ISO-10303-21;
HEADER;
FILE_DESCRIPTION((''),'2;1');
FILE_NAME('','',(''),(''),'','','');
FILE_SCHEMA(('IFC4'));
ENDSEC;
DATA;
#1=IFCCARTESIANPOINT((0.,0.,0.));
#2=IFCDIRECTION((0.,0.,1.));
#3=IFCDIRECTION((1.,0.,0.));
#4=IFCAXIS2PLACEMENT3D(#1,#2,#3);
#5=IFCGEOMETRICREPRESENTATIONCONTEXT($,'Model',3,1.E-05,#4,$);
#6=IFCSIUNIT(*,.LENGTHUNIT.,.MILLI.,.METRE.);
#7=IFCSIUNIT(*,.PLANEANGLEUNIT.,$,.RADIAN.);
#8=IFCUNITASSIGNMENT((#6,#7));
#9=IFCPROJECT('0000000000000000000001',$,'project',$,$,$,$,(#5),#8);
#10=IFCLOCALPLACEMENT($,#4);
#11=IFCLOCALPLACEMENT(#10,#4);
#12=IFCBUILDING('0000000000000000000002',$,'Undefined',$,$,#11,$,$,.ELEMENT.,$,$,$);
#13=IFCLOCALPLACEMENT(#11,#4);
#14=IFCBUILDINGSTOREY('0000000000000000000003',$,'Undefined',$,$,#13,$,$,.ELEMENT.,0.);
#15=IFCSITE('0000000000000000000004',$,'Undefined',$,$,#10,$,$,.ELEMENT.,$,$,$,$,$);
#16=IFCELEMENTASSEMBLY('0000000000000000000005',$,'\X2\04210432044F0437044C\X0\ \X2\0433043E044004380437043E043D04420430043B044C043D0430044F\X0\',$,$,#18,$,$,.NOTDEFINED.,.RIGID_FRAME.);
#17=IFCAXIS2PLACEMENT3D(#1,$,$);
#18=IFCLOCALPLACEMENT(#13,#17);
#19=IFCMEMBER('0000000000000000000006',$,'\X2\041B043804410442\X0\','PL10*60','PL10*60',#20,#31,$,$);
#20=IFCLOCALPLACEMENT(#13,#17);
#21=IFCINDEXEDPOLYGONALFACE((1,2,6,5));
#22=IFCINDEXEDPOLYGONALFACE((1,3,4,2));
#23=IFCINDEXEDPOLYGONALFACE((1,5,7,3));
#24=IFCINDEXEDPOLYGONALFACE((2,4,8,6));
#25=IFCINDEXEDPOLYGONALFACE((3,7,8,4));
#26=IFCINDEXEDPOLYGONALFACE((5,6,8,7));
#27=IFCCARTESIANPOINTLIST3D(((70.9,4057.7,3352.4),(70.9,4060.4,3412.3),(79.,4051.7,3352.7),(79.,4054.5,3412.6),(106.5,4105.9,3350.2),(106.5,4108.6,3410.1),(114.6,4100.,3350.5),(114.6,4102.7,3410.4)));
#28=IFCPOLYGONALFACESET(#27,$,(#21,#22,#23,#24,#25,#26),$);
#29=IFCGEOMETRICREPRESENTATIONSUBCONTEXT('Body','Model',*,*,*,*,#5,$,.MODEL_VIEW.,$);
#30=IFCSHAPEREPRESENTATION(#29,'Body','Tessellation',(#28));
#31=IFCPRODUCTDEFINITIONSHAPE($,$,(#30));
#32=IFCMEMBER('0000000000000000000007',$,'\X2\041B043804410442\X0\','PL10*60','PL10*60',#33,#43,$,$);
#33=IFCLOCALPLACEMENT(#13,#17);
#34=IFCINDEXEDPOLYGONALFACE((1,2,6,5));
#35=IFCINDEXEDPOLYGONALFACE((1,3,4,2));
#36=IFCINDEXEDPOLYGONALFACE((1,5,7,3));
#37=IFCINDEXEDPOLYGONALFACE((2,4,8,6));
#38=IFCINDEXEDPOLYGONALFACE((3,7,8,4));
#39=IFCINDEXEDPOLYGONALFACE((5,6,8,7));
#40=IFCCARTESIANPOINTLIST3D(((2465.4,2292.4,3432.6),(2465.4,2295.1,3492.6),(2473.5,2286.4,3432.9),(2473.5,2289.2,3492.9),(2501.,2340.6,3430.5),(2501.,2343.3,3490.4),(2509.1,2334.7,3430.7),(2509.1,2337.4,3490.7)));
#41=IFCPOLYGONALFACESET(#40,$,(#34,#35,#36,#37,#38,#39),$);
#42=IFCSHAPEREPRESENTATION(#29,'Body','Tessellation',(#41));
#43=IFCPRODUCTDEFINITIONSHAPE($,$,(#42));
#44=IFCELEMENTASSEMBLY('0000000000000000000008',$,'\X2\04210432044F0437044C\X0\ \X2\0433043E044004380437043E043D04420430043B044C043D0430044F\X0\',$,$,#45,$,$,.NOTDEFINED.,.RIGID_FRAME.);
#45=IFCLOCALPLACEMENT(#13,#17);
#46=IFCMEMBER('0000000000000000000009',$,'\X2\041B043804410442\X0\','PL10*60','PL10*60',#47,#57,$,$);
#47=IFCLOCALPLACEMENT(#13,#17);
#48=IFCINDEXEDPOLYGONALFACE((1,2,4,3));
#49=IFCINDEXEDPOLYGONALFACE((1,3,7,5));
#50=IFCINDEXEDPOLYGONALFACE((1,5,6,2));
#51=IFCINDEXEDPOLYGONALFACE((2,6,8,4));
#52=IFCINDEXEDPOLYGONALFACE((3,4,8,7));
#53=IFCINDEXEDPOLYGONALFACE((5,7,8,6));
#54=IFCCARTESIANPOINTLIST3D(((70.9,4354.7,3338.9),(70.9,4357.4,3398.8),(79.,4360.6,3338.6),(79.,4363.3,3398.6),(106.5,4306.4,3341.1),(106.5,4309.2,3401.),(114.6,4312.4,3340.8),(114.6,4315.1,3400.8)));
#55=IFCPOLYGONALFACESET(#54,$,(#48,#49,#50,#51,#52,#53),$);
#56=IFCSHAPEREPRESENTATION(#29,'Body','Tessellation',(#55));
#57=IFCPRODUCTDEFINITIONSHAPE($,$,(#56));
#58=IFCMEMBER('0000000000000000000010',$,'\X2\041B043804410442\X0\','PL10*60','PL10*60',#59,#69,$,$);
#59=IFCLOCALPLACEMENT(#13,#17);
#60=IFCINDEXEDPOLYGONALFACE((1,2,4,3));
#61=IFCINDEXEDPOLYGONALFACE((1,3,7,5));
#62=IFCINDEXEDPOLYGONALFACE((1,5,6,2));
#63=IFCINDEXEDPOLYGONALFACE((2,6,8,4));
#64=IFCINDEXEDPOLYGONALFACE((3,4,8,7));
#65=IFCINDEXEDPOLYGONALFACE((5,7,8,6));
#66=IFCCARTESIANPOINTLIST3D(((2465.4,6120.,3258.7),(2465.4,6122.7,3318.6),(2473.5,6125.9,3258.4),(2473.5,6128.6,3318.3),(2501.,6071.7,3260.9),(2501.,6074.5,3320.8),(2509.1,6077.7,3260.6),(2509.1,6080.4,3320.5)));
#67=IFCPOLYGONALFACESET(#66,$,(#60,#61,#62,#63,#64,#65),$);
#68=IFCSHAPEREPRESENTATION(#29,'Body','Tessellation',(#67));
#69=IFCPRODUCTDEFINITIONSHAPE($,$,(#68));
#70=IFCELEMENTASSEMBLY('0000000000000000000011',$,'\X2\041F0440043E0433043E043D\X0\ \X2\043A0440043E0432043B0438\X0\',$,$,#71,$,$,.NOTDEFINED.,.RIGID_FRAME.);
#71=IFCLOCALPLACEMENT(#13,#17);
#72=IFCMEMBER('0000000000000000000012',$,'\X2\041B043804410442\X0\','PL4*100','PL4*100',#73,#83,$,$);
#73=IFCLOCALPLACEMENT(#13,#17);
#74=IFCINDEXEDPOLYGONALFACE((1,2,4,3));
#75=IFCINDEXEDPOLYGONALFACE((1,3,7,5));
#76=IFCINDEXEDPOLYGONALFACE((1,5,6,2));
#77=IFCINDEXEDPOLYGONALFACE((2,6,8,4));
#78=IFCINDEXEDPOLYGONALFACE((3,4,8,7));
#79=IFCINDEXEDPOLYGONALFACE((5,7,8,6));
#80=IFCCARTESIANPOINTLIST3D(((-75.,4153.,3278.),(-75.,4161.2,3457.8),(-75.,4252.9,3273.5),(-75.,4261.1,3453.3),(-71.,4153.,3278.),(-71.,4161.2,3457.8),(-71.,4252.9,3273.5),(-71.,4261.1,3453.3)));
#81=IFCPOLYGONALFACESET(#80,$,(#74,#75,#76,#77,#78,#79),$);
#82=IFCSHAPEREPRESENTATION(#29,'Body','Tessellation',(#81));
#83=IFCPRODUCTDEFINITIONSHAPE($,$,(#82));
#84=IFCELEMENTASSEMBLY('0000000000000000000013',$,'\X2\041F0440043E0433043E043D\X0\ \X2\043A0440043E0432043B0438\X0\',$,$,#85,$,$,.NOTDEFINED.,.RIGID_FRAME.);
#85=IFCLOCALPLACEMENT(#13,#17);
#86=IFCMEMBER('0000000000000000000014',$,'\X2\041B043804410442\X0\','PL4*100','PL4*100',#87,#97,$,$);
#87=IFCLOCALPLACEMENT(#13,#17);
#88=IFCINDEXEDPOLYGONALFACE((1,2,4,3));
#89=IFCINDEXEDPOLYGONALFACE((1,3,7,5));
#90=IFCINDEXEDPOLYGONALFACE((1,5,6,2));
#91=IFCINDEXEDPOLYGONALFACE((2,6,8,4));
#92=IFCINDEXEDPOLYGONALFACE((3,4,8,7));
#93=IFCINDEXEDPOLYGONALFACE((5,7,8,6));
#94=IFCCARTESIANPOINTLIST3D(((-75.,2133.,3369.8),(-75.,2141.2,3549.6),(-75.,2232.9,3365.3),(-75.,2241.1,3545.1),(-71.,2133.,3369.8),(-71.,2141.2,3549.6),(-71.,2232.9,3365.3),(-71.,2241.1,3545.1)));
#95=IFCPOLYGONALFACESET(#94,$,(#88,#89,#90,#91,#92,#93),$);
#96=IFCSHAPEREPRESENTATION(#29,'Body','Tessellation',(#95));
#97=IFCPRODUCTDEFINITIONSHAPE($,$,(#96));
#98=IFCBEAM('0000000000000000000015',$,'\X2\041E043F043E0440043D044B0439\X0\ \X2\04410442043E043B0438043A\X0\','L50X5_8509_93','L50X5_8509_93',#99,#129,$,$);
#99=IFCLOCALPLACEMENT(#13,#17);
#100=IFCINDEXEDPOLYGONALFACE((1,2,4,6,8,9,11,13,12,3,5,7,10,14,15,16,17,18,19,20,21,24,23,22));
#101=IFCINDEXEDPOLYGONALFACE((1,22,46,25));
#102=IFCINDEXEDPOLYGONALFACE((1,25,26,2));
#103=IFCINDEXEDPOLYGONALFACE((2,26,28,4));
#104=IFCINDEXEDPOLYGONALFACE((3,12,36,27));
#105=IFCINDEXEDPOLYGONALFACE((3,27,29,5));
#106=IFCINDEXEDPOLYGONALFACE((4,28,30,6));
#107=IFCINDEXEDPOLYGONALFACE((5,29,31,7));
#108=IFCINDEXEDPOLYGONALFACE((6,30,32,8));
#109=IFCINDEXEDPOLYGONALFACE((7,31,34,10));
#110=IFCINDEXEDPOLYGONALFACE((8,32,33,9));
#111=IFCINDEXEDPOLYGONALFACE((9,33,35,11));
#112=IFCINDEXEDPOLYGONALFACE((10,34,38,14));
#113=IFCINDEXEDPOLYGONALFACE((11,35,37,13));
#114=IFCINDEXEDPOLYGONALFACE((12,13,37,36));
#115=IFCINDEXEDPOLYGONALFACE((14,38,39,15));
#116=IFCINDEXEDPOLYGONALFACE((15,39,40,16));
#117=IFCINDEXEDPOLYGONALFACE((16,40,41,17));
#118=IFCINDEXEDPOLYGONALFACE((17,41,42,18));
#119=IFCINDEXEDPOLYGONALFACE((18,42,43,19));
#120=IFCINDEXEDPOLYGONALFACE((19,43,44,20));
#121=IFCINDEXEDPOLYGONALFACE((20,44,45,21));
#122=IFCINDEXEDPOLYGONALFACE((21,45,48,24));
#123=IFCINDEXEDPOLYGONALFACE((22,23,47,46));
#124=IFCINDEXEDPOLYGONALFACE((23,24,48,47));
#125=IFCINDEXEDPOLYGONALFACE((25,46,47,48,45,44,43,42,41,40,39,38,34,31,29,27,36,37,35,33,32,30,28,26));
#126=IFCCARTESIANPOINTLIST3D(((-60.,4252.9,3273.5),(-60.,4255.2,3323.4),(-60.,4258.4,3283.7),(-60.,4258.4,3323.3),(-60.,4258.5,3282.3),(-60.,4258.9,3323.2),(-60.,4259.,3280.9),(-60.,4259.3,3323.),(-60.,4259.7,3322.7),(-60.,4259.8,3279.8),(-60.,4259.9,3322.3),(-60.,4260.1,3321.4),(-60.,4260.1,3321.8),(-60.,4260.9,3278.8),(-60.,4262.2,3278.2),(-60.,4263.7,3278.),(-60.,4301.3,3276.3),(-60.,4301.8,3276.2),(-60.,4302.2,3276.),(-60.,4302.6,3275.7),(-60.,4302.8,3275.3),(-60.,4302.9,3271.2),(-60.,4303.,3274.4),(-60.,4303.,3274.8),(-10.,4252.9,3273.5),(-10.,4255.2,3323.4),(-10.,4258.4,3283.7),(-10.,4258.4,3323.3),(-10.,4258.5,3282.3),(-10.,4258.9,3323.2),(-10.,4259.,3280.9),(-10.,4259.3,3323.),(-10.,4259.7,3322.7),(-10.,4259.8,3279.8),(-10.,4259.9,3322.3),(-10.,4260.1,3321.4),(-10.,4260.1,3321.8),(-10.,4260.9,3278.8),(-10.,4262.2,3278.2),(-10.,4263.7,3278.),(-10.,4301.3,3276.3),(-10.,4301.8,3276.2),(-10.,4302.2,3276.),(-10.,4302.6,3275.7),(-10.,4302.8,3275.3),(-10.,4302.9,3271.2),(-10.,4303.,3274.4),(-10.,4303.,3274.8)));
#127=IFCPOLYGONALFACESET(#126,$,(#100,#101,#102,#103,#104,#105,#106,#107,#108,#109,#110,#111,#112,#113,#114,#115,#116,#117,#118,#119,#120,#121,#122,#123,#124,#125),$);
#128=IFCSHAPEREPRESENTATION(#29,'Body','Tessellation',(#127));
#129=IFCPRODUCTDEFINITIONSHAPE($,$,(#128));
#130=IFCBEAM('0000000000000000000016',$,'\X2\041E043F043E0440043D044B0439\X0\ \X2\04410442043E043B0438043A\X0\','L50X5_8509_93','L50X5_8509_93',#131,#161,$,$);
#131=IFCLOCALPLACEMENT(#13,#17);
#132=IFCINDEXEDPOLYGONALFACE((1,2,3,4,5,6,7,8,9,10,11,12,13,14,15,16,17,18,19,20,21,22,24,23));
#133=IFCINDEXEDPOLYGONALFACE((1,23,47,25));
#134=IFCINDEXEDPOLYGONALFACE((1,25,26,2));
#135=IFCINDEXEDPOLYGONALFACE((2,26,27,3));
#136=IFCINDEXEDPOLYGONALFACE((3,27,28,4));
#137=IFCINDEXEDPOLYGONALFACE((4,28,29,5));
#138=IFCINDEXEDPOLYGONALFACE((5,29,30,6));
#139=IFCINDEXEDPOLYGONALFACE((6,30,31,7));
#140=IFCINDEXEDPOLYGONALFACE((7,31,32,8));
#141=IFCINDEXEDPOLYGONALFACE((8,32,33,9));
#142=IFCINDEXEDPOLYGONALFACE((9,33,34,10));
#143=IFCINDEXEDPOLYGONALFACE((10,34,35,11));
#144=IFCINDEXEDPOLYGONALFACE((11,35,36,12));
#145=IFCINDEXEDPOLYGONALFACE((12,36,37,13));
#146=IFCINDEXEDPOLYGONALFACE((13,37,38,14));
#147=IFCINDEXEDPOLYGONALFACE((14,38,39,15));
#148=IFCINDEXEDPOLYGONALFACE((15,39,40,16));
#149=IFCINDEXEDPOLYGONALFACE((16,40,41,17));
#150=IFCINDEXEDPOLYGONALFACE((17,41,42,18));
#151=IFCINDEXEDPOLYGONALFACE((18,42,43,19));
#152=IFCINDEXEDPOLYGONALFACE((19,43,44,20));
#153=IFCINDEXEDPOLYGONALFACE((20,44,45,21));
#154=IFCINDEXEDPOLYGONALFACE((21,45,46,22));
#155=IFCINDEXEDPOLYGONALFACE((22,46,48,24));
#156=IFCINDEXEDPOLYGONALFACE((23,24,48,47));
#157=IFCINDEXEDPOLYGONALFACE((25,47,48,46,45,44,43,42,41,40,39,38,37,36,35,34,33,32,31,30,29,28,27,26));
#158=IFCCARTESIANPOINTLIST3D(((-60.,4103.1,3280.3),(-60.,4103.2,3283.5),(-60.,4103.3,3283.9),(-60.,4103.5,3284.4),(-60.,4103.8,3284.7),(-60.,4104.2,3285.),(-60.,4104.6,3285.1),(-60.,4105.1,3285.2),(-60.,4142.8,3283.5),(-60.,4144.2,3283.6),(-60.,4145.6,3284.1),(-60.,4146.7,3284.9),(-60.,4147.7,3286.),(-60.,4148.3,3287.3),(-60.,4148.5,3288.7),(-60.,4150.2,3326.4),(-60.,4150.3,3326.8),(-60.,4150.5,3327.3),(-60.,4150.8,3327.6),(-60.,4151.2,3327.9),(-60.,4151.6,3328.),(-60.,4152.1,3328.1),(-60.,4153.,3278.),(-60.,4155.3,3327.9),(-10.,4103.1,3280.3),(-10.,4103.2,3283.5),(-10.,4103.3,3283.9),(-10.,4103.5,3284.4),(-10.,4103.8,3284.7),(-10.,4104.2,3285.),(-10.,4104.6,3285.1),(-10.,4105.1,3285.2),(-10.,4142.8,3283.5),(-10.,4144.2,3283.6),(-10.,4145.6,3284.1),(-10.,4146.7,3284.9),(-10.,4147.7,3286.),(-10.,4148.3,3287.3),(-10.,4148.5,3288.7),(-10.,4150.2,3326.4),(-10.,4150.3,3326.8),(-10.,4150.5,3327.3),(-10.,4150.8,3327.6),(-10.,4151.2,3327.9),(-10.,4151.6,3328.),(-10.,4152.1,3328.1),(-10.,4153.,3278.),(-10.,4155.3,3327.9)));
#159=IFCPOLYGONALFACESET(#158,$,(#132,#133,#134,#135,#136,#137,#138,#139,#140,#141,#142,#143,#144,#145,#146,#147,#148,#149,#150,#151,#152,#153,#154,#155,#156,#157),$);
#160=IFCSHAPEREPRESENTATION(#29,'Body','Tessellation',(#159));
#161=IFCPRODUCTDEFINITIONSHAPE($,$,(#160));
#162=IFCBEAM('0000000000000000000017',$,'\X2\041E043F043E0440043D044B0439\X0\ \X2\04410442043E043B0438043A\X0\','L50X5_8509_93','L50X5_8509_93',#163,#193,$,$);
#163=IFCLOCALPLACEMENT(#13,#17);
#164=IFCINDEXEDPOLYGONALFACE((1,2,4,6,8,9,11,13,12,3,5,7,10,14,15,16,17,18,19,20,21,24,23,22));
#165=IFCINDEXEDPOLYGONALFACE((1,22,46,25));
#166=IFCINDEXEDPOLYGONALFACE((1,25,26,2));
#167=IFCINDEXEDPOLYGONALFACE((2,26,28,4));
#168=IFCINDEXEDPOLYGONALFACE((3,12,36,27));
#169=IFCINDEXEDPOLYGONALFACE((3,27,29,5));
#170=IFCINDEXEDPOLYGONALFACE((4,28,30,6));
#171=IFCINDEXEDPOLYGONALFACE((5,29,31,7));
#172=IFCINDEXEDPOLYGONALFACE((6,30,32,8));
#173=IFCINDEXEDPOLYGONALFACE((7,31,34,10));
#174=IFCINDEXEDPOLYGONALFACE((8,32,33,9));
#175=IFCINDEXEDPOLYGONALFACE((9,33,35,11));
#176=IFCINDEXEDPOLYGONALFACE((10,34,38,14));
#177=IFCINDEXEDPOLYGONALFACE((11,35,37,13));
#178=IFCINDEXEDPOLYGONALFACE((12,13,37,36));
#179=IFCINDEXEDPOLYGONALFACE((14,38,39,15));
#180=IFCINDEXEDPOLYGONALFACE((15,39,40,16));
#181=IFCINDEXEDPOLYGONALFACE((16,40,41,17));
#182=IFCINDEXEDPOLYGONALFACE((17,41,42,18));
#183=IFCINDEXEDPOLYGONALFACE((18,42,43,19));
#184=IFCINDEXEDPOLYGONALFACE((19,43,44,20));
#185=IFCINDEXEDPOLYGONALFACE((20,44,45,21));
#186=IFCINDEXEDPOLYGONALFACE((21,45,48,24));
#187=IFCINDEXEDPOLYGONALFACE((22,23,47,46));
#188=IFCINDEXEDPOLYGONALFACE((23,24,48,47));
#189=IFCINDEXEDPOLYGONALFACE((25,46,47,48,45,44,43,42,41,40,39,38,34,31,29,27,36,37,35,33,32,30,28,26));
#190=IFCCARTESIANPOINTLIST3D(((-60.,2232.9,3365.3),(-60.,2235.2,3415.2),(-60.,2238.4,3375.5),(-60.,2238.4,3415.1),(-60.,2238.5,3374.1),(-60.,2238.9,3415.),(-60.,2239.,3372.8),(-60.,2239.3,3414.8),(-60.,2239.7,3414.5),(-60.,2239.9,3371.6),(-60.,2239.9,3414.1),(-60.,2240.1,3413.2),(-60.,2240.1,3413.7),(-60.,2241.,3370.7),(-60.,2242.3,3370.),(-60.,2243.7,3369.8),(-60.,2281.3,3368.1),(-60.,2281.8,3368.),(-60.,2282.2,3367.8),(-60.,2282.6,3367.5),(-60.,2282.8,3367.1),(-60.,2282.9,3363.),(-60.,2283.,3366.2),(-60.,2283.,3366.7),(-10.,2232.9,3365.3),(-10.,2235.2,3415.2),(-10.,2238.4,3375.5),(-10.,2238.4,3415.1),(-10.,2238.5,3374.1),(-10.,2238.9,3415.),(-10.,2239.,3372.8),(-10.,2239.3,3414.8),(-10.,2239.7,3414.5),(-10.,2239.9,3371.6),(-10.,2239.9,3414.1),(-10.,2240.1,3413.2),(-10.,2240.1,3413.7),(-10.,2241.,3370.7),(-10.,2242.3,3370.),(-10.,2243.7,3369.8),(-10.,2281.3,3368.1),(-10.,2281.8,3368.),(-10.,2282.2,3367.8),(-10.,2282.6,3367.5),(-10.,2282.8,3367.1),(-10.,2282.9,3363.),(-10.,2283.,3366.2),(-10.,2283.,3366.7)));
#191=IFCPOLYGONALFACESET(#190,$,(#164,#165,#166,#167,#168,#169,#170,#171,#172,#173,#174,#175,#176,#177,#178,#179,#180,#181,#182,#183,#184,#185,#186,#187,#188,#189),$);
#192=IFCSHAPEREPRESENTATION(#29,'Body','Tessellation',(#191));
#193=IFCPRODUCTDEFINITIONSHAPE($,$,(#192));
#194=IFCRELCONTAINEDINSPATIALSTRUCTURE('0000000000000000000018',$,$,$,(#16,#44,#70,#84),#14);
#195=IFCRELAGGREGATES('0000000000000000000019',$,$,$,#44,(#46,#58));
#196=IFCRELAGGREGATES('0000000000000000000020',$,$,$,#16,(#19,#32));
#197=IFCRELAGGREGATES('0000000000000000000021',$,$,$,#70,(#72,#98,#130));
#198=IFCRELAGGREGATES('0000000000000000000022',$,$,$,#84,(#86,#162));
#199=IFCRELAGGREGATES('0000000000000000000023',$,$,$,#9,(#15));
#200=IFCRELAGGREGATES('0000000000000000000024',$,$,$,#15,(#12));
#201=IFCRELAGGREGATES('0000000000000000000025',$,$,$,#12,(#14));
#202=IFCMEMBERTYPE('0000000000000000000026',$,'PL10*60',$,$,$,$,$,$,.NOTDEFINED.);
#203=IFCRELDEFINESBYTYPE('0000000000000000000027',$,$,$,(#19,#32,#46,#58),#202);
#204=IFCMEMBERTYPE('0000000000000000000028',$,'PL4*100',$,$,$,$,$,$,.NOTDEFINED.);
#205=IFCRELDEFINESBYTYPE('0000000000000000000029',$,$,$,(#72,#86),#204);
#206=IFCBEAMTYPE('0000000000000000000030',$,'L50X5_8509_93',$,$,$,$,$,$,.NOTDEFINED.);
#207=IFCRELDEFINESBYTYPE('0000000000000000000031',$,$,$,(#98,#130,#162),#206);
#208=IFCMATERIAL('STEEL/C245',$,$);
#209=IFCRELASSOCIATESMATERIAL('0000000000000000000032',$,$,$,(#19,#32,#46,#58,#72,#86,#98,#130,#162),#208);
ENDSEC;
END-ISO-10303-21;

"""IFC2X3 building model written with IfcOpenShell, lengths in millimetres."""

from ifc_helpers import new_model, si_unit, frame, origin_with_axes, origin_2d_with_axis, place, context, subcontext, project, spatial, rectangle, l_section, extrude, material, type_object, element, aggregate, save


model = new_model("IFC2X3")

# Units and contexts
model_context = context("Model", 3, precision=1e-05, world=origin_with_axes())
body_context = subcontext(model_context, "Body", "Model", "MODEL_VIEW")
ifc_project = project(units=[si_unit("LENGTHUNIT", "METRE", prefix="MILLI"), si_unit("PLANEANGLEUNIT", "RADIAN")], contexts=[model_context])

# Site, building, storey
site_placement = place(None, origin_with_axes())
site = spatial("IfcSite", under=ifc_project, at=site_placement, Name="Undefined", CompositionType="ELEMENT")
building_placement = place(site_placement, origin_with_axes())
building = spatial("IfcBuilding", under=site, at=building_placement, Name="Undefined", CompositionType="ELEMENT")
storey_placement = place(building_placement, origin_with_axes())
storey = spatial("IfcBuildingStorey", under=building, at=storey_placement, Name="Undefined", CompositionType="ELEMENT", Elevation=0.0)

# Element assemblies, members
assembly_1_placement = place(storey_placement, origin_with_axes())
assembly_1 = element("IfcElementAssembly", 1, at=assembly_1_placement, inside=storey, Name="Связь горизонтальная", AssemblyPlace="NOTDEFINED", PredefinedType="RIGID_FRAME")
ifc_material_1 = material(Name="STEEL/C245")
member_type_1 = type_object("IfcMemberType", Name="PL10*60", PredefinedType="NOTDEFINED")
member_1_placement = place(assembly_1_placement, frame((92.7, 4081.5, 3411.4), z_axis=(-0.593795, -0.803786, 0.036536), x_axis=(0.0, -0.045408, -0.998969)))
member_1 = element("IfcMember", 2, at=member_1_placement, type_object=member_type_1, material=ifc_material_1, Name="Лист", Description="PL10*60", ObjectType="PL10*60", context=body_context, shape_type="SweptSolid", body=[
    extrude(rectangle(XDim=10.0, YDim=60.0, at=origin_2d_with_axis()), frame((60.0, 0.0, 0.0), z_axis=(-1.0, 0.0, 0.0), x_axis=(0.0, -1.0, 0.0)), (0.0, 0.0, 1.0), 60.0),
])
member_2_placement = place(assembly_1_placement, frame((2487.3, 2313.5, 3431.7), z_axis=(-0.593795, -0.803786, 0.036536), x_axis=(0.0, 0.045408, 0.998969)))
member_2 = element("IfcMember", 3, at=member_2_placement, type_object=member_type_1, material=ifc_material_1, Name="Лист", Description="PL10*60", ObjectType="PL10*60", context=body_context, shape_type="SweptSolid", body=[
    extrude(rectangle(XDim=10.0, YDim=60.0, at=origin_2d_with_axis()), frame((60.0, 0.0, 0.0), z_axis=(-1.0, 0.0, 0.0), x_axis=(0.0, -1.0, 0.0)), (0.0, 0.0, 1.0), 60.0),
])
assembly_2_placement = place(storey_placement, origin_with_axes())
assembly_2 = element("IfcElementAssembly", 4, at=assembly_2_placement, inside=storey, Name="Связь горизонтальная", AssemblyPlace="NOTDEFINED", PredefinedType="RIGID_FRAME")
member_3_placement = place(assembly_2_placement, frame((92.7, 4333.5, 3339.9), z_axis=(-0.593795, 0.803786, -0.036536), x_axis=(0.0, 0.045408, 0.998969)))
member_3 = element("IfcMember", 5, at=member_3_placement, type_object=member_type_1, material=ifc_material_1, Name="Лист", Description="PL10*60", ObjectType="PL10*60", context=body_context, shape_type="SweptSolid", body=[
    extrude(rectangle(XDim=10.0, YDim=60.0, at=origin_2d_with_axis()), frame((60.0, 0.0, 0.0), z_axis=(-1.0, 0.0, 0.0), x_axis=(0.0, -1.0, 0.0)), (0.0, 0.0, 1.0), 60.0),
])
member_4_placement = place(assembly_2_placement, frame((2487.3, 6098.8, 3259.6), z_axis=(0.593795, -0.803786, 0.036536), x_axis=(0.0, 0.045408, 0.998969)))
member_4 = element("IfcMember", 6, at=member_4_placement, type_object=member_type_1, material=ifc_material_1, Name="Лист", Description="PL10*60", ObjectType="PL10*60", context=body_context, shape_type="SweptSolid", body=[
    extrude(rectangle(XDim=10.0, YDim=60.0, at=origin_2d_with_axis()), frame((60.0, 0.0, 0.0), z_axis=(-1.0, 0.0, 0.0), x_axis=(0.0, -1.0, 0.0)), (0.0, 0.0, 1.0), 60.0),
])

# Element assemblies, members
assembly_3_placement = place(storey_placement, origin_with_axes())
assembly_3 = element("IfcElementAssembly", 7, at=assembly_3_placement, inside=storey, Name="Прогон кровли", AssemblyPlace="NOTDEFINED", PredefinedType="RIGID_FRAME")
member_type_2 = type_object("IfcMemberType", Name="PL4*100", PredefinedType="NOTDEFINED")
member_5_placement = place(assembly_3_placement, frame((-73.0, 4203.0, 3275.7), z_axis=(0.0, -0.998969, 0.045408), x_axis=(0.0, 0.045408, 0.998969)))
member_5 = element("IfcMember", 8, at=member_5_placement, type_object=member_type_2, material=ifc_material_1, Name="Лист", Description="PL4*100", ObjectType="PL4*100", context=body_context, shape_type="SweptSolid", body=[
    extrude(rectangle(XDim=4.0, YDim=100.0, at=origin_2d_with_axis()), frame((180.0, 0.0, 0.0), z_axis=(-1.0, 0.0, 0.0), x_axis=(0.0, -1.0, 0.0)), (0.0, 0.0, 1.0), 180.0),
])
assembly_4_placement = place(storey_placement, origin_with_axes())
assembly_4 = element("IfcElementAssembly", 9, at=assembly_4_placement, inside=storey, Name="Прогон кровли", AssemblyPlace="NOTDEFINED", PredefinedType="RIGID_FRAME")
member_6_placement = place(assembly_4_placement, frame((-73.0, 2183.0, 3367.5), z_axis=(0.0, -0.998969, 0.045408), x_axis=(0.0, 0.045408, 0.998969)))
member_6 = element("IfcMember", 10, at=member_6_placement, type_object=member_type_2, material=ifc_material_1, Name="Лист", Description="PL4*100", ObjectType="PL4*100", context=body_context, shape_type="SweptSolid", body=[
    extrude(rectangle(XDim=4.0, YDim=100.0, at=origin_2d_with_axis()), frame((180.0, 0.0, 0.0), z_axis=(-1.0, 0.0, 0.0), x_axis=(0.0, -1.0, 0.0)), (0.0, 0.0, 1.0), 180.0),
])

# Beams
beam_type_1 = type_object("IfcBeamType", Name="L50X5_8509_93", PredefinedType="NOTDEFINED")
beam_1_placement = place(assembly_3_placement, frame((-60.0, 4279.1, 3297.3), z_axis=(0.0, 0.998969, -0.045408), x_axis=(1.0, 0.0, 0.0)))
beam_1 = element("IfcBeam", 11, at=beam_1_placement, type_object=beam_type_1, material=ifc_material_1, Name="Опорный столик", Description="L50X5_8509_93", ObjectType="L50X5_8509_93", context=body_context, shape_type="SweptSolid", body=[
    extrude(l_section(Depth=50.0, Width=50.0, Thickness=5.0, FilletRadius=5.5, EdgeRadius=1.8, at=origin_2d_with_axis()), frame((50.0, 0.0, 0.0), z_axis=(-1.0, 0.0, 0.0), x_axis=(0.0, -1.0, 0.0)), (0.0, 0.0, 1.0), 50.0),
])
beam_2_placement = place(assembly_3_placement, frame((-10.0, 4129.2, 3304.1), z_axis=(0.0, -0.998969, 0.045408), x_axis=(-1.0, 0.0, 0.0)))
beam_2 = element("IfcBeam", 12, at=beam_2_placement, type_object=beam_type_1, material=ifc_material_1, Name="Опорный столик", Description="L50X5_8509_93", ObjectType="L50X5_8509_93", context=body_context, shape_type="SweptSolid", body=[
    extrude(l_section(Depth=50.0, Width=50.0, Thickness=5.0, FilletRadius=5.5, EdgeRadius=1.8, at=origin_2d_with_axis()), frame((50.0, 0.0, 0.0), z_axis=(-1.0, 0.0, 0.0), x_axis=(0.0, -1.0, 0.0)), (0.0, 0.0, 1.0), 50.0),
])
beam_3_placement = place(assembly_4_placement, frame((-60.0, 2259.1, 3389.1), z_axis=(0.0, 0.998969, -0.045408), x_axis=(1.0, 0.0, 0.0)))
beam_3 = element("IfcBeam", 13, at=beam_3_placement, type_object=beam_type_1, material=ifc_material_1, Name="Опорный столик", Description="L50X5_8509_93", ObjectType="L50X5_8509_93", context=body_context, shape_type="SweptSolid", body=[
    extrude(l_section(Depth=50.0, Width=50.0, Thickness=5.0, FilletRadius=5.5, EdgeRadius=1.8, at=origin_2d_with_axis()), frame((50.0, 0.0, 0.0), z_axis=(-1.0, 0.0, 0.0), x_axis=(0.0, -1.0, 0.0)), (0.0, 0.0, 1.0), 50.0),
])

aggregate(assembly_2, [member_3, member_4])
aggregate(assembly_1, [member_1, member_2])
aggregate(assembly_3, [member_5, beam_1, beam_2])
aggregate(assembly_4, [member_6, beam_3])

save(model, "model.ifc")
